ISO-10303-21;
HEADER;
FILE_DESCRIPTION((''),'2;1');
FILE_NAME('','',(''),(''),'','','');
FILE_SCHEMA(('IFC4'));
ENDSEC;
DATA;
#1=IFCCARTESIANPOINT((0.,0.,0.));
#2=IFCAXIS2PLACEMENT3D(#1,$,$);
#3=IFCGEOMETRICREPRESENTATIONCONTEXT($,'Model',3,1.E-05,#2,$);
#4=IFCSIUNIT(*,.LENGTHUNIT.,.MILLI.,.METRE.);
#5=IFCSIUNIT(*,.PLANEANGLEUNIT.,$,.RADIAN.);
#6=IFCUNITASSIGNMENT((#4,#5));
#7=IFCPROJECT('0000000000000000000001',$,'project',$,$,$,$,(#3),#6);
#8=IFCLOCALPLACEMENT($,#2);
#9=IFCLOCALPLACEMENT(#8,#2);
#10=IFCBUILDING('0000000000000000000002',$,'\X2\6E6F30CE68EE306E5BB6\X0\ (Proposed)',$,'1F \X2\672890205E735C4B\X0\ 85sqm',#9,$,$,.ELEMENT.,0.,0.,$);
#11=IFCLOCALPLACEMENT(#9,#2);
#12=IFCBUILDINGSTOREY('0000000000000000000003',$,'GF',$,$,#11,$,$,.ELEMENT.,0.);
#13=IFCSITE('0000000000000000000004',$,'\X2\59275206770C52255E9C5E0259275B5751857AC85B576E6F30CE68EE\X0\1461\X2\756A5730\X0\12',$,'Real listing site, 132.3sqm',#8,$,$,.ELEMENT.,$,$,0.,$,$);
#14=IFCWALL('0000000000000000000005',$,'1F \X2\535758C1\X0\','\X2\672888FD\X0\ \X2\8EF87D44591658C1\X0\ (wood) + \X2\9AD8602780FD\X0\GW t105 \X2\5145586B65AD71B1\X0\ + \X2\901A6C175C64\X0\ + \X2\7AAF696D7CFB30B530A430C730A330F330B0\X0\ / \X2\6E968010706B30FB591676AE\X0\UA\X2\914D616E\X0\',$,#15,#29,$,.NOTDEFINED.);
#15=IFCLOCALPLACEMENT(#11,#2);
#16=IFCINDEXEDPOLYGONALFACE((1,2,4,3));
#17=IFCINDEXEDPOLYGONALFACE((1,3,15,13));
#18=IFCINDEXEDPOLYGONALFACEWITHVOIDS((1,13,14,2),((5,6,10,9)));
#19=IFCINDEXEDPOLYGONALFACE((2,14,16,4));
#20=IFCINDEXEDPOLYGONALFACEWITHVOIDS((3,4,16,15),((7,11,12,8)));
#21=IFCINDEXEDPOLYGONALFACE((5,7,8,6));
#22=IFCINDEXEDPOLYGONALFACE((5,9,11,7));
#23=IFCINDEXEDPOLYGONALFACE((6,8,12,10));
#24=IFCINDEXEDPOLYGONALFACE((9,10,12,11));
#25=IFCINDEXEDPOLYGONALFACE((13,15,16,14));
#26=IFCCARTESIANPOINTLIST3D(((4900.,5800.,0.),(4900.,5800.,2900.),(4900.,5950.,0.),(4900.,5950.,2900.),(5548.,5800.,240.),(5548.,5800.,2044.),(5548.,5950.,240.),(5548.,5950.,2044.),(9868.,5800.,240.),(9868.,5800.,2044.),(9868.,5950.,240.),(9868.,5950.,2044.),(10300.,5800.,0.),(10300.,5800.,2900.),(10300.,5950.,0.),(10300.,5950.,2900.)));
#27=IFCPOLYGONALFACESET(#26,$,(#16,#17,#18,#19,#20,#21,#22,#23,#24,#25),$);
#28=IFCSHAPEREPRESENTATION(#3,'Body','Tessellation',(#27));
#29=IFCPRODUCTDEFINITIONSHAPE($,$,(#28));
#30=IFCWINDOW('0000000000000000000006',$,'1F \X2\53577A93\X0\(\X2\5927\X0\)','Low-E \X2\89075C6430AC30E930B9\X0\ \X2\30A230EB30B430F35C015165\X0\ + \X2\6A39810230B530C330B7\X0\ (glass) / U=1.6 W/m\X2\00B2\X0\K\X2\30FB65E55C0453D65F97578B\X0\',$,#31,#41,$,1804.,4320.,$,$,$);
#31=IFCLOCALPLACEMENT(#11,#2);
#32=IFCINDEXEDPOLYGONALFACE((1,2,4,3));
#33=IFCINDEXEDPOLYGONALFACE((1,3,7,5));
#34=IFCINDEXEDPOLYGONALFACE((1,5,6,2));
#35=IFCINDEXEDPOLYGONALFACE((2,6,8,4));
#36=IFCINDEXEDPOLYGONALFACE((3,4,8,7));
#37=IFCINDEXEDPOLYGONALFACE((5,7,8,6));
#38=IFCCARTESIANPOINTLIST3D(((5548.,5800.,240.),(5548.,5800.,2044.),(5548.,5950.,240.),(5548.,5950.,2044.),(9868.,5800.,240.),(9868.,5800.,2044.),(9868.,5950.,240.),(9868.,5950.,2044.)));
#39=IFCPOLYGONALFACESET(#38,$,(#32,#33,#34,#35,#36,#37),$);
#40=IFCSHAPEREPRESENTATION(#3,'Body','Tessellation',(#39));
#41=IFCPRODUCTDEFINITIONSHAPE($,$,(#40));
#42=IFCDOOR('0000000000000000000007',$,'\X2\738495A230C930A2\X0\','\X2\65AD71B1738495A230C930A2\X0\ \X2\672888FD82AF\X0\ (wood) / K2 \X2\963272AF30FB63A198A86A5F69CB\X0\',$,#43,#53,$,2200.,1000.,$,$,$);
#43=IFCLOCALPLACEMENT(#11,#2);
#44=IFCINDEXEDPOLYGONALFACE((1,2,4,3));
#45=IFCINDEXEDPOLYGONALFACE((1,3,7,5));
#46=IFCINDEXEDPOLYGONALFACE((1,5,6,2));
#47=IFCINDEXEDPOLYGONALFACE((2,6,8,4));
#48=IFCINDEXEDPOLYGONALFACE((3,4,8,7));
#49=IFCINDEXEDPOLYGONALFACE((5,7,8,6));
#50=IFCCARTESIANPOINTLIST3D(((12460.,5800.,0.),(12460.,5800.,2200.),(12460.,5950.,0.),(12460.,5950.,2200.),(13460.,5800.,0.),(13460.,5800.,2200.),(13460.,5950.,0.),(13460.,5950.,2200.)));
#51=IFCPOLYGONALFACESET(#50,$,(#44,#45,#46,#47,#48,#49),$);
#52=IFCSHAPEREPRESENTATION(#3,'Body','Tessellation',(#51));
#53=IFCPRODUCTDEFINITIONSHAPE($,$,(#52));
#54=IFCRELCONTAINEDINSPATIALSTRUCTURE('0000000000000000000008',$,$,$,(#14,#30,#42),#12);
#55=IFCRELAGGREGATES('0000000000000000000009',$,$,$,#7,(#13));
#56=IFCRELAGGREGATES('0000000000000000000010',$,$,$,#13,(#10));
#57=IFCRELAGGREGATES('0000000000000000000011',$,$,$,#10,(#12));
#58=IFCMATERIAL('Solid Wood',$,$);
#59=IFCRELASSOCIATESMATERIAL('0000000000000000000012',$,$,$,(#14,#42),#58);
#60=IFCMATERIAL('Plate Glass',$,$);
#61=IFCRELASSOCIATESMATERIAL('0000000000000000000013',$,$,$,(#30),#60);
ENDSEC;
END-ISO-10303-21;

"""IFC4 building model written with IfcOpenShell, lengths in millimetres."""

from ifc_helpers import new_model, si_unit, frame, frame_2d, origin, place, context, project, spatial, rectangle, extrude, material, element, fill, save


model = new_model("IFC4")

# Units and contexts
model_context = context("Model", 3, precision=1e-05, world=origin())
ifc_project = project(units=[si_unit("LENGTHUNIT", "METRE", prefix="MILLI"), si_unit("PLANEANGLEUNIT", "RADIAN")], contexts=[model_context])

# Site, building, storey
site_placement = place(None, origin())
site = spatial("IfcSite", under=ifc_project, at=site_placement, Name="大分県別府市大字内竈字湯ノ森1461番地12", ObjectType="Real listing site, 132.3sqm", CompositionType="ELEMENT", RefElevation=0.0)
building_placement = place(site_placement, origin())
building = spatial("IfcBuilding", under=site, at=building_placement, Name="湯ノ森の家 (Proposed)", ObjectType="1F 木造平屋 85sqm", CompositionType="ELEMENT", ElevationOfRefHeight=0.0, ElevationOfTerrain=0.0)
storey_placement = place(building_placement, origin())
storey = spatial("IfcBuildingStorey", under=building, at=storey_placement, Name="GF", CompositionType="ELEMENT", Elevation=0.0)

# Shared definitions
ifc_material_1 = material(Name="Solid Wood")

# Wall, openings, window, door
wall_1_placement = place(storey_placement, frame((2450.0, 2900.0, 0.0)))
wall_1 = element("IfcWall", 1, at=wall_1_placement, inside=storey, material=ifc_material_1, Name="1F 南壁", Description="木製 軸組外壁 (wood) + 高性能GW t105 充填断熱 + 通気層 + 窯業系サイディング / 準耐火・外皮UA配慮", PredefinedType="NOTDEFINED", context=model_context, shape_type="SweptSolid", body=[
    extrude(rectangle(XDim=5400.0, YDim=150.0, at=frame_2d((2700.0, 75.0))), frame((2450.0, 2900.0, 0.0)), (0.0, 0.0, 1.0), 2900.0),
])
opening_1_placement = place(storey_placement, frame((2774.0, 2900.0, 120.0)))
opening_1 = element("IfcOpeningElement", 2, at=opening_1_placement, cuts=wall_1, PredefinedType="NOTDEFINED", context=model_context, shape_type="SweptSolid", body=[
    extrude(rectangle(XDim=4320.0, YDim=150.0, at=frame_2d((2160.0, 75.0))), frame((2774.0, 2900.0, 120.0)), (0.0, 0.0, 1.0), 1804.0),
])
opening_2_placement = place(storey_placement, frame((6230.0, 2900.0, 0.0)))
opening_2 = element("IfcOpeningElement", 3, at=opening_2_placement, cuts=wall_1, PredefinedType="NOTDEFINED", context=model_context, shape_type="SweptSolid", body=[
    extrude(rectangle(XDim=1000.0, YDim=150.0, at=frame_2d((500.0, 75.0))), frame((6230.0, 2900.0, 0.0)), (0.0, 0.0, 1.0), 2200.0),
])
ifc_material_2 = material(Name="Plate Glass")
window_1_placement = place(storey_placement, frame((2774.0, 2900.0, 120.0)))
window_1 = element("IfcWindow", 4, at=window_1_placement, inside=storey, material=ifc_material_2, Name="1F 南窓(大)", Description="Low-E 複層ガラス アルゴン封入 + 樹脂サッシ (glass) / U=1.6 W/m²K・日射取得型", OverallHeight=1804.0, OverallWidth=4320.0, context=model_context, shape_type="SweptSolid", body=[
    extrude(rectangle(XDim=4320.0, YDim=150.0, at=frame_2d((2160.0, 75.0))), frame((2774.0, 2900.0, 120.0)), (0.0, 0.0, 1.0), 1804.0),
])
fill(opening_1, window_1)
door_placement = place(storey_placement, frame((6230.0, 2900.0, 0.0)))
door = element("IfcDoor", 5, at=door_placement, inside=storey, material=ifc_material_1, Name="玄関ドア", Description="断熱玄関ドア 木製芯 (wood) / K2 防犯・採風機構", OverallHeight=2200.0, OverallWidth=1000.0, context=model_context, shape_type="SweptSolid", body=[
    extrude(rectangle(XDim=1000.0, YDim=150.0, at=frame_2d((500.0, 75.0))), frame((6230.0, 2900.0, 0.0)), (0.0, 0.0, 1.0), 2200.0),
])
fill(opening_2, door)

save(model, "model.ifc")
